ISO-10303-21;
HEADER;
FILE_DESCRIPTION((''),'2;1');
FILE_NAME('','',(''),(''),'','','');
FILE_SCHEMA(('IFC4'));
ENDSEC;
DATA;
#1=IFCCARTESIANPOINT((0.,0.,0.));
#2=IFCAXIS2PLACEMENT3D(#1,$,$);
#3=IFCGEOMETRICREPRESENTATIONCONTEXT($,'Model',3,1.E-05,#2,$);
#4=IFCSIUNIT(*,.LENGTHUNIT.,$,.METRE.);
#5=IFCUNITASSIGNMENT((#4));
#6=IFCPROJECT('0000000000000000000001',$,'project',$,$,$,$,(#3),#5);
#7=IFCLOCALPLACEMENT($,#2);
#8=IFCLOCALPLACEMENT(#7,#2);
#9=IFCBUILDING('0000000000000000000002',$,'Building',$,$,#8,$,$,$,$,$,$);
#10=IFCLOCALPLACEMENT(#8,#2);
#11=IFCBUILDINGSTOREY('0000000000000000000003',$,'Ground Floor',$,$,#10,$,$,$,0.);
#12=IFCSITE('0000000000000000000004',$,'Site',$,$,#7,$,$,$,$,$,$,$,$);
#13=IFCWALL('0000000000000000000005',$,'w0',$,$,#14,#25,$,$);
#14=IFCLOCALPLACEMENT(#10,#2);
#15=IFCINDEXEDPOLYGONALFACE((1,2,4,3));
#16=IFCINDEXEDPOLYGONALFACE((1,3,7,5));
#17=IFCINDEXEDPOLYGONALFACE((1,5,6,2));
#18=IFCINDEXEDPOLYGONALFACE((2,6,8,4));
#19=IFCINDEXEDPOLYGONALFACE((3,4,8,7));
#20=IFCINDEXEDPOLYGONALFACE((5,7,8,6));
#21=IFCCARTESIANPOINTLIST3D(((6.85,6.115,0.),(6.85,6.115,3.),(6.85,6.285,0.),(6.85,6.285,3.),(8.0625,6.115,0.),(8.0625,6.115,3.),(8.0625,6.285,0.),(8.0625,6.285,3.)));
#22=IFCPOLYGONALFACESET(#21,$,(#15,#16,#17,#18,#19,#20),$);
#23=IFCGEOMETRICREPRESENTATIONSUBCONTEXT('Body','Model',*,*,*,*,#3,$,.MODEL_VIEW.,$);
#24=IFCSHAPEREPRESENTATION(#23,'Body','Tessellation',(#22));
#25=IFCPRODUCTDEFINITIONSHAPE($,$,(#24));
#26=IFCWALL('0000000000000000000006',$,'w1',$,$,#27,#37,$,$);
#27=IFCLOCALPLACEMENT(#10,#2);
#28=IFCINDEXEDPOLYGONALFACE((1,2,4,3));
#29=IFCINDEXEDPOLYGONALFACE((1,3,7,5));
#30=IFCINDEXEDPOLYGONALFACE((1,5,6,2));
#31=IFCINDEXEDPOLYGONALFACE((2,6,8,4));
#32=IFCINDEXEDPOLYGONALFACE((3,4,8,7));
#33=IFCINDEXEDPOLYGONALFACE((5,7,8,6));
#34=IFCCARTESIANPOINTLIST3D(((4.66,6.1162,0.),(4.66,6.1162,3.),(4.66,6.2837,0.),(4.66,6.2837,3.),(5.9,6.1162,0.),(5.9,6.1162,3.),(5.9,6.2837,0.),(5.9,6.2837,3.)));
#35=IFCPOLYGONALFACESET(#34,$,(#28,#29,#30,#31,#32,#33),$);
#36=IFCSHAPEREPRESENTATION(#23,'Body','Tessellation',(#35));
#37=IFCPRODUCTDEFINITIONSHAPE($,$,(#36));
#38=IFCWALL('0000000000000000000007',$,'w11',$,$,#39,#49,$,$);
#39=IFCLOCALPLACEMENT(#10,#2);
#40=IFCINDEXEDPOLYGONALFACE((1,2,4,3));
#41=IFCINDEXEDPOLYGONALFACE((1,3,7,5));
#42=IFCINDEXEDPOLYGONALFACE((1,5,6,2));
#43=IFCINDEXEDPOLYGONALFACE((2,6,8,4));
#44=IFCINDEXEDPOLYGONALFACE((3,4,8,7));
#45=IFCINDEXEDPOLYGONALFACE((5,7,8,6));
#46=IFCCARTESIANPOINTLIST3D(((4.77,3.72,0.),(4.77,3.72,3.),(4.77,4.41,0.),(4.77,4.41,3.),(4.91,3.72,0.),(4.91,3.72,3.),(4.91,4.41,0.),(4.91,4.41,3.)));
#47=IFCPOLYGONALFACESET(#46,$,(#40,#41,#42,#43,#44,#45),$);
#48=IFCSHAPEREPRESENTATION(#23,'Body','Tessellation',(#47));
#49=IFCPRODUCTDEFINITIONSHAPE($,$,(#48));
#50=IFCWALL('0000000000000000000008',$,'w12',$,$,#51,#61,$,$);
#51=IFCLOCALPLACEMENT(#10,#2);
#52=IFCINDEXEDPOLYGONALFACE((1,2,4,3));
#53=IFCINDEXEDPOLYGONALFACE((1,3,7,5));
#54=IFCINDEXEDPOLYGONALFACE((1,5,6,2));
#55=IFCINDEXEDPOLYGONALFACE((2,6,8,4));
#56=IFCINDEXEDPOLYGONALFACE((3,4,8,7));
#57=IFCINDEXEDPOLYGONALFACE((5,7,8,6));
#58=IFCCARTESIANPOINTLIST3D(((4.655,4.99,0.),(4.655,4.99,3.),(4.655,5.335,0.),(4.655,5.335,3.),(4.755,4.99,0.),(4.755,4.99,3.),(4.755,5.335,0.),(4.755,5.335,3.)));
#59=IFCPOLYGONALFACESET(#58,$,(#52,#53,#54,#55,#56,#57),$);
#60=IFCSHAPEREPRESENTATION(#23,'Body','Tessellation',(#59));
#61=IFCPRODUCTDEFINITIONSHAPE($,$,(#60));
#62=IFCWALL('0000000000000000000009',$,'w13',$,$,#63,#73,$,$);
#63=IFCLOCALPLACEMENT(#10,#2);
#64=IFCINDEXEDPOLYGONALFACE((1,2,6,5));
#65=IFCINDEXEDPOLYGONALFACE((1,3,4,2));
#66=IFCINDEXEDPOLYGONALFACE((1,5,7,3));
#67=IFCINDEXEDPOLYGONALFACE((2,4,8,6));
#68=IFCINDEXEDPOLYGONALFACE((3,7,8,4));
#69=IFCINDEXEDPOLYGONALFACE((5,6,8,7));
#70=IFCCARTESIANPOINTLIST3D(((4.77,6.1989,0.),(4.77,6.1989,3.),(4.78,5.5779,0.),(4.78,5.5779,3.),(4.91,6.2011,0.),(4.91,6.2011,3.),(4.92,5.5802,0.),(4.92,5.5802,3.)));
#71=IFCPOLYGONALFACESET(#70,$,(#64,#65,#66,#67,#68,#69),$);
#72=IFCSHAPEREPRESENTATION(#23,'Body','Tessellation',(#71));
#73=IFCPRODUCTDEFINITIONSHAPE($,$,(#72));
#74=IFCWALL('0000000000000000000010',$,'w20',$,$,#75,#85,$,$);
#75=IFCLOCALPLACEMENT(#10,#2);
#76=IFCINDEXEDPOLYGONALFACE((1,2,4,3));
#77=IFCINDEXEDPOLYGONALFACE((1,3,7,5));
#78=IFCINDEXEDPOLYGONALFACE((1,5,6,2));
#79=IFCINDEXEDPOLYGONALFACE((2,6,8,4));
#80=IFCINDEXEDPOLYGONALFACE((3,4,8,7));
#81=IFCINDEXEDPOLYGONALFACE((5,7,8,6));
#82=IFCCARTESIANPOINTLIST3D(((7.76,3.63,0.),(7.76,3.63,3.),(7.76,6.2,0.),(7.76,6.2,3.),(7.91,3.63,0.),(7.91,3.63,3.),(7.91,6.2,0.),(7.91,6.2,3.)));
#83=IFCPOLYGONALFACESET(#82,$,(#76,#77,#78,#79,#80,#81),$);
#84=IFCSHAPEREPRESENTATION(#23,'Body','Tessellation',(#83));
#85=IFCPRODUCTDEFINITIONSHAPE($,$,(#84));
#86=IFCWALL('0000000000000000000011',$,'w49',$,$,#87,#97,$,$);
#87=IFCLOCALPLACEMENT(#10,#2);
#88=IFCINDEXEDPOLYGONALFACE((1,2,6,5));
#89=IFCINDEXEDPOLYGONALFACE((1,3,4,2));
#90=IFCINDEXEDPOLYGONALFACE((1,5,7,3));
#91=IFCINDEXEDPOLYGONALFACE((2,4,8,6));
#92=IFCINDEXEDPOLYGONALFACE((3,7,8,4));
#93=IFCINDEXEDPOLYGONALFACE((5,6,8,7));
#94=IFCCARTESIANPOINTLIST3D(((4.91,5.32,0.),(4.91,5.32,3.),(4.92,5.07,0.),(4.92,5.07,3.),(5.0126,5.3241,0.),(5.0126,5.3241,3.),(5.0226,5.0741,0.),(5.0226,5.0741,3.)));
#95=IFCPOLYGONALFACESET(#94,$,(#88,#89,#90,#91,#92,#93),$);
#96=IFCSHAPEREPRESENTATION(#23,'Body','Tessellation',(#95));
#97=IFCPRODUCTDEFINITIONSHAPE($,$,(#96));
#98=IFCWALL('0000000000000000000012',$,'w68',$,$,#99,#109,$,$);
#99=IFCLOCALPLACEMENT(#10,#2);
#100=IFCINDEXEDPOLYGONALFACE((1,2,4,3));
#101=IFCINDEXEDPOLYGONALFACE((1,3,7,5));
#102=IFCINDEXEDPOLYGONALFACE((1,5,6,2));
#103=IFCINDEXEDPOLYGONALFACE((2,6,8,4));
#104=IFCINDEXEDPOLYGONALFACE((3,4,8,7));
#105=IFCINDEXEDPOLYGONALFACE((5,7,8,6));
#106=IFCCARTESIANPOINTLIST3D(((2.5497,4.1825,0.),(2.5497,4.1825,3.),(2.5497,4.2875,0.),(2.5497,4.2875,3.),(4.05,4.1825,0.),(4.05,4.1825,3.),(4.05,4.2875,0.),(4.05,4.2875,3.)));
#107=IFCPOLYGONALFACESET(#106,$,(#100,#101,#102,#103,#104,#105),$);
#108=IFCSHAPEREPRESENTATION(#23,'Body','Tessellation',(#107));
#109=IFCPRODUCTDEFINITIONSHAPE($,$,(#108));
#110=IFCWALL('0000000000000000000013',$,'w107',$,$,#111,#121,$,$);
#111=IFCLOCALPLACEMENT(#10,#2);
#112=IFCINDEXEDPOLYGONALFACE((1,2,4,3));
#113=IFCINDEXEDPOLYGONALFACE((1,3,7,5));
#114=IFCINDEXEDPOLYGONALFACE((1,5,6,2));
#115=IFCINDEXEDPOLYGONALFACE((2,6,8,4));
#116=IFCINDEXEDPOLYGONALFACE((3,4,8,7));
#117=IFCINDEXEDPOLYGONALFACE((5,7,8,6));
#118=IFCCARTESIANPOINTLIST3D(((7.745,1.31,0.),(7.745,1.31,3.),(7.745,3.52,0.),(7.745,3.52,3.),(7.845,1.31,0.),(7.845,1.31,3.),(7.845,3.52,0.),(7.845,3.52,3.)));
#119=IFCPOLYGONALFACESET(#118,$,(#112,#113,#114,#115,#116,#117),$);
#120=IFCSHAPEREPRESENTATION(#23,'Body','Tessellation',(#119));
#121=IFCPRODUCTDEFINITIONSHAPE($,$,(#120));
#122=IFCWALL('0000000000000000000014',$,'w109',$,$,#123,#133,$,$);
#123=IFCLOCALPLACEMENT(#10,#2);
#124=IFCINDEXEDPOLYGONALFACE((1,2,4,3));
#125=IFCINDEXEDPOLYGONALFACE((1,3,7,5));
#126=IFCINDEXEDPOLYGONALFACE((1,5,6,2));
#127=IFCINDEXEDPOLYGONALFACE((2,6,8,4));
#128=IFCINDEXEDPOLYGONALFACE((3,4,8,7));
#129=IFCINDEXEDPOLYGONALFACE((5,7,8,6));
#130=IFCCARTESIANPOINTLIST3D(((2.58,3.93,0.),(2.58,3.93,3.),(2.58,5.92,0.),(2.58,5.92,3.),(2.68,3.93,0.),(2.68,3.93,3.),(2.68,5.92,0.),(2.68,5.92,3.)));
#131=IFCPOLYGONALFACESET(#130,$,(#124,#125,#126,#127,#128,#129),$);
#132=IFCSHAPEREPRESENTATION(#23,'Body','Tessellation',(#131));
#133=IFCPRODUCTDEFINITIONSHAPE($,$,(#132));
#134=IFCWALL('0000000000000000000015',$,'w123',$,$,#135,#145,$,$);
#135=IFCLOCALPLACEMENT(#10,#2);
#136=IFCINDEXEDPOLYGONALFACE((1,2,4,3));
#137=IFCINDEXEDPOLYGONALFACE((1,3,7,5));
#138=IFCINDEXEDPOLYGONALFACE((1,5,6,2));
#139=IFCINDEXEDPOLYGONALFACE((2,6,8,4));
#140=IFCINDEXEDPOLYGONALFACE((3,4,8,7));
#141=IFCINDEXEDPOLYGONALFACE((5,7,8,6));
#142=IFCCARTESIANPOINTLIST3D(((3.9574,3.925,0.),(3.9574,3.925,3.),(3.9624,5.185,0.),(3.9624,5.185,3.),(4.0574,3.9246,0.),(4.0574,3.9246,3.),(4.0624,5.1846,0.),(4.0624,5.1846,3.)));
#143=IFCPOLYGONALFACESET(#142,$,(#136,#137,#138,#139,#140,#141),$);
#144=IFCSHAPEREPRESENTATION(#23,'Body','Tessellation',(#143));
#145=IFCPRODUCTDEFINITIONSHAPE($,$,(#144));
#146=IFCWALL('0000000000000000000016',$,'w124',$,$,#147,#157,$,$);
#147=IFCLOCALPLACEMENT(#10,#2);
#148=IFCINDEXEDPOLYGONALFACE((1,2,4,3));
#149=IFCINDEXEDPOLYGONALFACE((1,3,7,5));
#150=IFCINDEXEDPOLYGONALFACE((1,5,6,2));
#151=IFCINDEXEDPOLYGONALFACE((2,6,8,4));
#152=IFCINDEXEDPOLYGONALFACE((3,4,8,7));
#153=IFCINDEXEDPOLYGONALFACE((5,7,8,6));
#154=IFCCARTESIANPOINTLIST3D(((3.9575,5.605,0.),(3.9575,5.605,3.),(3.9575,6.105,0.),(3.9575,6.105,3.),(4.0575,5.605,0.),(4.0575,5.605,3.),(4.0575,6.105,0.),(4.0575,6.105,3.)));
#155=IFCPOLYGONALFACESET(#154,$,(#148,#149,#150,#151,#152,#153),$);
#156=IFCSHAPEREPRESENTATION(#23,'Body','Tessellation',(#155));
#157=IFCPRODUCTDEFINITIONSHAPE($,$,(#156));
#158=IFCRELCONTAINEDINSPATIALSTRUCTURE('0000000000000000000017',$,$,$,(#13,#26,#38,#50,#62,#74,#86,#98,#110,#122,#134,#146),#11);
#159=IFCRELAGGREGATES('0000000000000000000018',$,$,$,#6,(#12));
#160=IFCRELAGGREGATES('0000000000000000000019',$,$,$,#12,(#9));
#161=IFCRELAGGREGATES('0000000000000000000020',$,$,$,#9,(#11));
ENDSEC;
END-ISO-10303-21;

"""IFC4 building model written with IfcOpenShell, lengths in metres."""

from ifc_helpers import new_model, si_unit, frame, origin, place, context, subcontext, project, spatial, polyline, outline, extrude, element, save


model = new_model("IFC4")

# Units and contexts
model_context = context("Model", 3, precision=1e-05, world=origin())
body_context = subcontext(model_context, "Body", "Model", "MODEL_VIEW")
ifc_project = project(units=[si_unit("LENGTHUNIT", "METRE")], contexts=[model_context])

# Site, building, storey
site_placement = place(None, origin())
site = spatial("IfcSite", under=ifc_project, at=site_placement, Name="Site")
building_placement = place(site_placement, origin())
building = spatial("IfcBuilding", under=site, at=building_placement, Name="Building")
storey_placement = place(building_placement, origin())
storey = spatial("IfcBuildingStorey", under=building, at=storey_placement, Name="Ground Floor", Elevation=0.0)

# Walls
wall_1_placement = place(storey_placement, frame((6.85, 6.2, 0.0), x_axis=(1.0, 0.0, 0.0)))
element("IfcWall", 1, at=wall_1_placement, inside=storey, Name="w0", context=body_context, shape_type="SweptSolid", body=[
    extrude(outline(polyline([(0.0, -0.085), (1.2125, -0.085), (1.2125, 0.085), (0.0, 0.085), (0.0, -0.085)])), origin(), (0.0, 0.0, 1.0), 3.0),
])
wall_2_placement = place(storey_placement, frame((4.66, 6.2, 0.0), x_axis=(1.0, 0.0, 0.0)))
element("IfcWall", 2, at=wall_2_placement, inside=storey, Name="w1", context=body_context, shape_type="SweptSolid", body=[
    extrude(outline(polyline([(0.0, -0.0837), (1.24, -0.0837), (1.24, 0.0837), (0.0, 0.0837), (0.0, -0.0837)])), origin(), (0.0, 0.0, 1.0), 3.0),
])
wall_3_placement = place(storey_placement, frame((4.84, 3.72, 0.0), x_axis=(0.0, 1.0, 0.0)))
element("IfcWall", 3, at=wall_3_placement, inside=storey, Name="w11", context=body_context, shape_type="SweptSolid", body=[
    extrude(outline(polyline([(0.0, -0.07), (0.69, -0.07), (0.69, 0.07), (0.0, 0.07), (0.0, -0.07)])), origin(), (0.0, 0.0, 1.0), 3.0),
])
wall_4_placement = place(storey_placement, frame((4.705, 4.99, 0.0), x_axis=(0.0, 1.0, 0.0)))
element("IfcWall", 4, at=wall_4_placement, inside=storey, Name="w12", context=body_context, shape_type="SweptSolid", body=[
    extrude(outline(polyline([(0.0, -0.05), (0.345, -0.05), (0.345, 0.05), (0.0, 0.05), (0.0, -0.05)])), origin(), (0.0, 0.0, 1.0), 3.0),
])
wall_5_placement = place(storey_placement, frame((4.84, 6.2, 0.0), x_axis=(0.016123, -0.99987, 0.0)))
element("IfcWall", 5, at=wall_5_placement, inside=storey, Name="w13", context=body_context, shape_type="SweptSolid", body=[
    extrude(outline(polyline([(0.0, -0.07), (0.621, -0.07), (0.621, 0.07), (0.0, 0.07), (0.0, -0.07)])), origin(), (0.0, 0.0, 1.0), 3.0),
])
wall_6_placement = place(storey_placement, frame((7.835, 3.63, 0.0), x_axis=(0.0, 1.0, 0.0)))
element("IfcWall", 6, at=wall_6_placement, inside=storey, Name="w20", context=body_context, shape_type="SweptSolid", body=[
    extrude(outline(polyline([(0.0, -0.075), (2.57, -0.075), (2.57, 0.075), (0.0, 0.075), (0.0, -0.075)])), origin(), (0.0, 0.0, 1.0), 3.0),
])
wall_7_placement = place(storey_placement, frame((4.9613, 5.3221, 0.0), x_axis=(0.03996, -0.999201, 0.0)))
element("IfcWall", 7, at=wall_7_placement, inside=storey, Name="w49", context=body_context, shape_type="SweptSolid", body=[
    extrude(outline(polyline([(0.0, -0.0514), (0.2502, -0.0514), (0.2502, 0.0514), (0.0, 0.0514), (0.0, -0.0514)])), origin(), (0.0, 0.0, 1.0), 3.0),
])
wall_8_placement = place(storey_placement, frame((2.5497, 4.235, 0.0), x_axis=(1.0, 0.0, 0.0)))
element("IfcWall", 8, at=wall_8_placement, inside=storey, Name="w68", context=body_context, shape_type="SweptSolid", body=[
    extrude(outline(polyline([(0.0, -0.0525), (1.5003, -0.0525), (1.5003, 0.0525), (0.0, 0.0525), (0.0, -0.0525)])), origin(), (0.0, 0.0, 1.0), 3.0),
])
wall_9_placement = place(storey_placement, frame((7.795, 1.31, 0.0), x_axis=(0.0, 1.0, 0.0)))
element("IfcWall", 9, at=wall_9_placement, inside=storey, Name="w107", context=body_context, shape_type="SweptSolid", body=[
    extrude(outline(polyline([(0.0, -0.05), (2.21, -0.05), (2.21, 0.05), (0.0, 0.05), (0.0, -0.05)])), origin(), (0.0, 0.0, 1.0), 3.0),
])
wall_10_placement = place(storey_placement, frame((2.63, 3.93, 0.0), x_axis=(0.0, 1.0, 0.0)))
element("IfcWall", 10, at=wall_10_placement, inside=storey, Name="w109", context=body_context, shape_type="SweptSolid", body=[
    extrude(outline(polyline([(0.0, -0.05), (1.99, -0.05), (1.99, 0.05), (0.0, 0.05), (0.0, -0.05)])), origin(), (0.0, 0.0, 1.0), 3.0),
])
wall_11_placement = place(storey_placement, frame((4.0074, 3.9248, 0.0), x_axis=(0.003968, 0.999992, 0.0)))
element("IfcWall", 11, at=wall_11_placement, inside=storey, Name="w123", context=body_context, shape_type="SweptSolid", body=[
    extrude(outline(polyline([(0.0, -0.05), (1.26, -0.05), (1.26, 0.05), (0.0, 0.05), (0.0, -0.05)])), origin(), (0.0, 0.0, 1.0), 3.0),
])
wall_12_placement = place(storey_placement, frame((4.0075, 5.605, 0.0), x_axis=(0.0, 1.0, 0.0)))
element("IfcWall", 12, at=wall_12_placement, inside=storey, Name="w124", context=body_context, shape_type="SweptSolid", body=[
    extrude(outline(polyline([(0.0, -0.05), (0.5, -0.05), (0.5, 0.05), (0.0, 0.05), (0.0, -0.05)])), origin(), (0.0, 0.0, 1.0), 3.0),
])

save(model, "model.ifc")
